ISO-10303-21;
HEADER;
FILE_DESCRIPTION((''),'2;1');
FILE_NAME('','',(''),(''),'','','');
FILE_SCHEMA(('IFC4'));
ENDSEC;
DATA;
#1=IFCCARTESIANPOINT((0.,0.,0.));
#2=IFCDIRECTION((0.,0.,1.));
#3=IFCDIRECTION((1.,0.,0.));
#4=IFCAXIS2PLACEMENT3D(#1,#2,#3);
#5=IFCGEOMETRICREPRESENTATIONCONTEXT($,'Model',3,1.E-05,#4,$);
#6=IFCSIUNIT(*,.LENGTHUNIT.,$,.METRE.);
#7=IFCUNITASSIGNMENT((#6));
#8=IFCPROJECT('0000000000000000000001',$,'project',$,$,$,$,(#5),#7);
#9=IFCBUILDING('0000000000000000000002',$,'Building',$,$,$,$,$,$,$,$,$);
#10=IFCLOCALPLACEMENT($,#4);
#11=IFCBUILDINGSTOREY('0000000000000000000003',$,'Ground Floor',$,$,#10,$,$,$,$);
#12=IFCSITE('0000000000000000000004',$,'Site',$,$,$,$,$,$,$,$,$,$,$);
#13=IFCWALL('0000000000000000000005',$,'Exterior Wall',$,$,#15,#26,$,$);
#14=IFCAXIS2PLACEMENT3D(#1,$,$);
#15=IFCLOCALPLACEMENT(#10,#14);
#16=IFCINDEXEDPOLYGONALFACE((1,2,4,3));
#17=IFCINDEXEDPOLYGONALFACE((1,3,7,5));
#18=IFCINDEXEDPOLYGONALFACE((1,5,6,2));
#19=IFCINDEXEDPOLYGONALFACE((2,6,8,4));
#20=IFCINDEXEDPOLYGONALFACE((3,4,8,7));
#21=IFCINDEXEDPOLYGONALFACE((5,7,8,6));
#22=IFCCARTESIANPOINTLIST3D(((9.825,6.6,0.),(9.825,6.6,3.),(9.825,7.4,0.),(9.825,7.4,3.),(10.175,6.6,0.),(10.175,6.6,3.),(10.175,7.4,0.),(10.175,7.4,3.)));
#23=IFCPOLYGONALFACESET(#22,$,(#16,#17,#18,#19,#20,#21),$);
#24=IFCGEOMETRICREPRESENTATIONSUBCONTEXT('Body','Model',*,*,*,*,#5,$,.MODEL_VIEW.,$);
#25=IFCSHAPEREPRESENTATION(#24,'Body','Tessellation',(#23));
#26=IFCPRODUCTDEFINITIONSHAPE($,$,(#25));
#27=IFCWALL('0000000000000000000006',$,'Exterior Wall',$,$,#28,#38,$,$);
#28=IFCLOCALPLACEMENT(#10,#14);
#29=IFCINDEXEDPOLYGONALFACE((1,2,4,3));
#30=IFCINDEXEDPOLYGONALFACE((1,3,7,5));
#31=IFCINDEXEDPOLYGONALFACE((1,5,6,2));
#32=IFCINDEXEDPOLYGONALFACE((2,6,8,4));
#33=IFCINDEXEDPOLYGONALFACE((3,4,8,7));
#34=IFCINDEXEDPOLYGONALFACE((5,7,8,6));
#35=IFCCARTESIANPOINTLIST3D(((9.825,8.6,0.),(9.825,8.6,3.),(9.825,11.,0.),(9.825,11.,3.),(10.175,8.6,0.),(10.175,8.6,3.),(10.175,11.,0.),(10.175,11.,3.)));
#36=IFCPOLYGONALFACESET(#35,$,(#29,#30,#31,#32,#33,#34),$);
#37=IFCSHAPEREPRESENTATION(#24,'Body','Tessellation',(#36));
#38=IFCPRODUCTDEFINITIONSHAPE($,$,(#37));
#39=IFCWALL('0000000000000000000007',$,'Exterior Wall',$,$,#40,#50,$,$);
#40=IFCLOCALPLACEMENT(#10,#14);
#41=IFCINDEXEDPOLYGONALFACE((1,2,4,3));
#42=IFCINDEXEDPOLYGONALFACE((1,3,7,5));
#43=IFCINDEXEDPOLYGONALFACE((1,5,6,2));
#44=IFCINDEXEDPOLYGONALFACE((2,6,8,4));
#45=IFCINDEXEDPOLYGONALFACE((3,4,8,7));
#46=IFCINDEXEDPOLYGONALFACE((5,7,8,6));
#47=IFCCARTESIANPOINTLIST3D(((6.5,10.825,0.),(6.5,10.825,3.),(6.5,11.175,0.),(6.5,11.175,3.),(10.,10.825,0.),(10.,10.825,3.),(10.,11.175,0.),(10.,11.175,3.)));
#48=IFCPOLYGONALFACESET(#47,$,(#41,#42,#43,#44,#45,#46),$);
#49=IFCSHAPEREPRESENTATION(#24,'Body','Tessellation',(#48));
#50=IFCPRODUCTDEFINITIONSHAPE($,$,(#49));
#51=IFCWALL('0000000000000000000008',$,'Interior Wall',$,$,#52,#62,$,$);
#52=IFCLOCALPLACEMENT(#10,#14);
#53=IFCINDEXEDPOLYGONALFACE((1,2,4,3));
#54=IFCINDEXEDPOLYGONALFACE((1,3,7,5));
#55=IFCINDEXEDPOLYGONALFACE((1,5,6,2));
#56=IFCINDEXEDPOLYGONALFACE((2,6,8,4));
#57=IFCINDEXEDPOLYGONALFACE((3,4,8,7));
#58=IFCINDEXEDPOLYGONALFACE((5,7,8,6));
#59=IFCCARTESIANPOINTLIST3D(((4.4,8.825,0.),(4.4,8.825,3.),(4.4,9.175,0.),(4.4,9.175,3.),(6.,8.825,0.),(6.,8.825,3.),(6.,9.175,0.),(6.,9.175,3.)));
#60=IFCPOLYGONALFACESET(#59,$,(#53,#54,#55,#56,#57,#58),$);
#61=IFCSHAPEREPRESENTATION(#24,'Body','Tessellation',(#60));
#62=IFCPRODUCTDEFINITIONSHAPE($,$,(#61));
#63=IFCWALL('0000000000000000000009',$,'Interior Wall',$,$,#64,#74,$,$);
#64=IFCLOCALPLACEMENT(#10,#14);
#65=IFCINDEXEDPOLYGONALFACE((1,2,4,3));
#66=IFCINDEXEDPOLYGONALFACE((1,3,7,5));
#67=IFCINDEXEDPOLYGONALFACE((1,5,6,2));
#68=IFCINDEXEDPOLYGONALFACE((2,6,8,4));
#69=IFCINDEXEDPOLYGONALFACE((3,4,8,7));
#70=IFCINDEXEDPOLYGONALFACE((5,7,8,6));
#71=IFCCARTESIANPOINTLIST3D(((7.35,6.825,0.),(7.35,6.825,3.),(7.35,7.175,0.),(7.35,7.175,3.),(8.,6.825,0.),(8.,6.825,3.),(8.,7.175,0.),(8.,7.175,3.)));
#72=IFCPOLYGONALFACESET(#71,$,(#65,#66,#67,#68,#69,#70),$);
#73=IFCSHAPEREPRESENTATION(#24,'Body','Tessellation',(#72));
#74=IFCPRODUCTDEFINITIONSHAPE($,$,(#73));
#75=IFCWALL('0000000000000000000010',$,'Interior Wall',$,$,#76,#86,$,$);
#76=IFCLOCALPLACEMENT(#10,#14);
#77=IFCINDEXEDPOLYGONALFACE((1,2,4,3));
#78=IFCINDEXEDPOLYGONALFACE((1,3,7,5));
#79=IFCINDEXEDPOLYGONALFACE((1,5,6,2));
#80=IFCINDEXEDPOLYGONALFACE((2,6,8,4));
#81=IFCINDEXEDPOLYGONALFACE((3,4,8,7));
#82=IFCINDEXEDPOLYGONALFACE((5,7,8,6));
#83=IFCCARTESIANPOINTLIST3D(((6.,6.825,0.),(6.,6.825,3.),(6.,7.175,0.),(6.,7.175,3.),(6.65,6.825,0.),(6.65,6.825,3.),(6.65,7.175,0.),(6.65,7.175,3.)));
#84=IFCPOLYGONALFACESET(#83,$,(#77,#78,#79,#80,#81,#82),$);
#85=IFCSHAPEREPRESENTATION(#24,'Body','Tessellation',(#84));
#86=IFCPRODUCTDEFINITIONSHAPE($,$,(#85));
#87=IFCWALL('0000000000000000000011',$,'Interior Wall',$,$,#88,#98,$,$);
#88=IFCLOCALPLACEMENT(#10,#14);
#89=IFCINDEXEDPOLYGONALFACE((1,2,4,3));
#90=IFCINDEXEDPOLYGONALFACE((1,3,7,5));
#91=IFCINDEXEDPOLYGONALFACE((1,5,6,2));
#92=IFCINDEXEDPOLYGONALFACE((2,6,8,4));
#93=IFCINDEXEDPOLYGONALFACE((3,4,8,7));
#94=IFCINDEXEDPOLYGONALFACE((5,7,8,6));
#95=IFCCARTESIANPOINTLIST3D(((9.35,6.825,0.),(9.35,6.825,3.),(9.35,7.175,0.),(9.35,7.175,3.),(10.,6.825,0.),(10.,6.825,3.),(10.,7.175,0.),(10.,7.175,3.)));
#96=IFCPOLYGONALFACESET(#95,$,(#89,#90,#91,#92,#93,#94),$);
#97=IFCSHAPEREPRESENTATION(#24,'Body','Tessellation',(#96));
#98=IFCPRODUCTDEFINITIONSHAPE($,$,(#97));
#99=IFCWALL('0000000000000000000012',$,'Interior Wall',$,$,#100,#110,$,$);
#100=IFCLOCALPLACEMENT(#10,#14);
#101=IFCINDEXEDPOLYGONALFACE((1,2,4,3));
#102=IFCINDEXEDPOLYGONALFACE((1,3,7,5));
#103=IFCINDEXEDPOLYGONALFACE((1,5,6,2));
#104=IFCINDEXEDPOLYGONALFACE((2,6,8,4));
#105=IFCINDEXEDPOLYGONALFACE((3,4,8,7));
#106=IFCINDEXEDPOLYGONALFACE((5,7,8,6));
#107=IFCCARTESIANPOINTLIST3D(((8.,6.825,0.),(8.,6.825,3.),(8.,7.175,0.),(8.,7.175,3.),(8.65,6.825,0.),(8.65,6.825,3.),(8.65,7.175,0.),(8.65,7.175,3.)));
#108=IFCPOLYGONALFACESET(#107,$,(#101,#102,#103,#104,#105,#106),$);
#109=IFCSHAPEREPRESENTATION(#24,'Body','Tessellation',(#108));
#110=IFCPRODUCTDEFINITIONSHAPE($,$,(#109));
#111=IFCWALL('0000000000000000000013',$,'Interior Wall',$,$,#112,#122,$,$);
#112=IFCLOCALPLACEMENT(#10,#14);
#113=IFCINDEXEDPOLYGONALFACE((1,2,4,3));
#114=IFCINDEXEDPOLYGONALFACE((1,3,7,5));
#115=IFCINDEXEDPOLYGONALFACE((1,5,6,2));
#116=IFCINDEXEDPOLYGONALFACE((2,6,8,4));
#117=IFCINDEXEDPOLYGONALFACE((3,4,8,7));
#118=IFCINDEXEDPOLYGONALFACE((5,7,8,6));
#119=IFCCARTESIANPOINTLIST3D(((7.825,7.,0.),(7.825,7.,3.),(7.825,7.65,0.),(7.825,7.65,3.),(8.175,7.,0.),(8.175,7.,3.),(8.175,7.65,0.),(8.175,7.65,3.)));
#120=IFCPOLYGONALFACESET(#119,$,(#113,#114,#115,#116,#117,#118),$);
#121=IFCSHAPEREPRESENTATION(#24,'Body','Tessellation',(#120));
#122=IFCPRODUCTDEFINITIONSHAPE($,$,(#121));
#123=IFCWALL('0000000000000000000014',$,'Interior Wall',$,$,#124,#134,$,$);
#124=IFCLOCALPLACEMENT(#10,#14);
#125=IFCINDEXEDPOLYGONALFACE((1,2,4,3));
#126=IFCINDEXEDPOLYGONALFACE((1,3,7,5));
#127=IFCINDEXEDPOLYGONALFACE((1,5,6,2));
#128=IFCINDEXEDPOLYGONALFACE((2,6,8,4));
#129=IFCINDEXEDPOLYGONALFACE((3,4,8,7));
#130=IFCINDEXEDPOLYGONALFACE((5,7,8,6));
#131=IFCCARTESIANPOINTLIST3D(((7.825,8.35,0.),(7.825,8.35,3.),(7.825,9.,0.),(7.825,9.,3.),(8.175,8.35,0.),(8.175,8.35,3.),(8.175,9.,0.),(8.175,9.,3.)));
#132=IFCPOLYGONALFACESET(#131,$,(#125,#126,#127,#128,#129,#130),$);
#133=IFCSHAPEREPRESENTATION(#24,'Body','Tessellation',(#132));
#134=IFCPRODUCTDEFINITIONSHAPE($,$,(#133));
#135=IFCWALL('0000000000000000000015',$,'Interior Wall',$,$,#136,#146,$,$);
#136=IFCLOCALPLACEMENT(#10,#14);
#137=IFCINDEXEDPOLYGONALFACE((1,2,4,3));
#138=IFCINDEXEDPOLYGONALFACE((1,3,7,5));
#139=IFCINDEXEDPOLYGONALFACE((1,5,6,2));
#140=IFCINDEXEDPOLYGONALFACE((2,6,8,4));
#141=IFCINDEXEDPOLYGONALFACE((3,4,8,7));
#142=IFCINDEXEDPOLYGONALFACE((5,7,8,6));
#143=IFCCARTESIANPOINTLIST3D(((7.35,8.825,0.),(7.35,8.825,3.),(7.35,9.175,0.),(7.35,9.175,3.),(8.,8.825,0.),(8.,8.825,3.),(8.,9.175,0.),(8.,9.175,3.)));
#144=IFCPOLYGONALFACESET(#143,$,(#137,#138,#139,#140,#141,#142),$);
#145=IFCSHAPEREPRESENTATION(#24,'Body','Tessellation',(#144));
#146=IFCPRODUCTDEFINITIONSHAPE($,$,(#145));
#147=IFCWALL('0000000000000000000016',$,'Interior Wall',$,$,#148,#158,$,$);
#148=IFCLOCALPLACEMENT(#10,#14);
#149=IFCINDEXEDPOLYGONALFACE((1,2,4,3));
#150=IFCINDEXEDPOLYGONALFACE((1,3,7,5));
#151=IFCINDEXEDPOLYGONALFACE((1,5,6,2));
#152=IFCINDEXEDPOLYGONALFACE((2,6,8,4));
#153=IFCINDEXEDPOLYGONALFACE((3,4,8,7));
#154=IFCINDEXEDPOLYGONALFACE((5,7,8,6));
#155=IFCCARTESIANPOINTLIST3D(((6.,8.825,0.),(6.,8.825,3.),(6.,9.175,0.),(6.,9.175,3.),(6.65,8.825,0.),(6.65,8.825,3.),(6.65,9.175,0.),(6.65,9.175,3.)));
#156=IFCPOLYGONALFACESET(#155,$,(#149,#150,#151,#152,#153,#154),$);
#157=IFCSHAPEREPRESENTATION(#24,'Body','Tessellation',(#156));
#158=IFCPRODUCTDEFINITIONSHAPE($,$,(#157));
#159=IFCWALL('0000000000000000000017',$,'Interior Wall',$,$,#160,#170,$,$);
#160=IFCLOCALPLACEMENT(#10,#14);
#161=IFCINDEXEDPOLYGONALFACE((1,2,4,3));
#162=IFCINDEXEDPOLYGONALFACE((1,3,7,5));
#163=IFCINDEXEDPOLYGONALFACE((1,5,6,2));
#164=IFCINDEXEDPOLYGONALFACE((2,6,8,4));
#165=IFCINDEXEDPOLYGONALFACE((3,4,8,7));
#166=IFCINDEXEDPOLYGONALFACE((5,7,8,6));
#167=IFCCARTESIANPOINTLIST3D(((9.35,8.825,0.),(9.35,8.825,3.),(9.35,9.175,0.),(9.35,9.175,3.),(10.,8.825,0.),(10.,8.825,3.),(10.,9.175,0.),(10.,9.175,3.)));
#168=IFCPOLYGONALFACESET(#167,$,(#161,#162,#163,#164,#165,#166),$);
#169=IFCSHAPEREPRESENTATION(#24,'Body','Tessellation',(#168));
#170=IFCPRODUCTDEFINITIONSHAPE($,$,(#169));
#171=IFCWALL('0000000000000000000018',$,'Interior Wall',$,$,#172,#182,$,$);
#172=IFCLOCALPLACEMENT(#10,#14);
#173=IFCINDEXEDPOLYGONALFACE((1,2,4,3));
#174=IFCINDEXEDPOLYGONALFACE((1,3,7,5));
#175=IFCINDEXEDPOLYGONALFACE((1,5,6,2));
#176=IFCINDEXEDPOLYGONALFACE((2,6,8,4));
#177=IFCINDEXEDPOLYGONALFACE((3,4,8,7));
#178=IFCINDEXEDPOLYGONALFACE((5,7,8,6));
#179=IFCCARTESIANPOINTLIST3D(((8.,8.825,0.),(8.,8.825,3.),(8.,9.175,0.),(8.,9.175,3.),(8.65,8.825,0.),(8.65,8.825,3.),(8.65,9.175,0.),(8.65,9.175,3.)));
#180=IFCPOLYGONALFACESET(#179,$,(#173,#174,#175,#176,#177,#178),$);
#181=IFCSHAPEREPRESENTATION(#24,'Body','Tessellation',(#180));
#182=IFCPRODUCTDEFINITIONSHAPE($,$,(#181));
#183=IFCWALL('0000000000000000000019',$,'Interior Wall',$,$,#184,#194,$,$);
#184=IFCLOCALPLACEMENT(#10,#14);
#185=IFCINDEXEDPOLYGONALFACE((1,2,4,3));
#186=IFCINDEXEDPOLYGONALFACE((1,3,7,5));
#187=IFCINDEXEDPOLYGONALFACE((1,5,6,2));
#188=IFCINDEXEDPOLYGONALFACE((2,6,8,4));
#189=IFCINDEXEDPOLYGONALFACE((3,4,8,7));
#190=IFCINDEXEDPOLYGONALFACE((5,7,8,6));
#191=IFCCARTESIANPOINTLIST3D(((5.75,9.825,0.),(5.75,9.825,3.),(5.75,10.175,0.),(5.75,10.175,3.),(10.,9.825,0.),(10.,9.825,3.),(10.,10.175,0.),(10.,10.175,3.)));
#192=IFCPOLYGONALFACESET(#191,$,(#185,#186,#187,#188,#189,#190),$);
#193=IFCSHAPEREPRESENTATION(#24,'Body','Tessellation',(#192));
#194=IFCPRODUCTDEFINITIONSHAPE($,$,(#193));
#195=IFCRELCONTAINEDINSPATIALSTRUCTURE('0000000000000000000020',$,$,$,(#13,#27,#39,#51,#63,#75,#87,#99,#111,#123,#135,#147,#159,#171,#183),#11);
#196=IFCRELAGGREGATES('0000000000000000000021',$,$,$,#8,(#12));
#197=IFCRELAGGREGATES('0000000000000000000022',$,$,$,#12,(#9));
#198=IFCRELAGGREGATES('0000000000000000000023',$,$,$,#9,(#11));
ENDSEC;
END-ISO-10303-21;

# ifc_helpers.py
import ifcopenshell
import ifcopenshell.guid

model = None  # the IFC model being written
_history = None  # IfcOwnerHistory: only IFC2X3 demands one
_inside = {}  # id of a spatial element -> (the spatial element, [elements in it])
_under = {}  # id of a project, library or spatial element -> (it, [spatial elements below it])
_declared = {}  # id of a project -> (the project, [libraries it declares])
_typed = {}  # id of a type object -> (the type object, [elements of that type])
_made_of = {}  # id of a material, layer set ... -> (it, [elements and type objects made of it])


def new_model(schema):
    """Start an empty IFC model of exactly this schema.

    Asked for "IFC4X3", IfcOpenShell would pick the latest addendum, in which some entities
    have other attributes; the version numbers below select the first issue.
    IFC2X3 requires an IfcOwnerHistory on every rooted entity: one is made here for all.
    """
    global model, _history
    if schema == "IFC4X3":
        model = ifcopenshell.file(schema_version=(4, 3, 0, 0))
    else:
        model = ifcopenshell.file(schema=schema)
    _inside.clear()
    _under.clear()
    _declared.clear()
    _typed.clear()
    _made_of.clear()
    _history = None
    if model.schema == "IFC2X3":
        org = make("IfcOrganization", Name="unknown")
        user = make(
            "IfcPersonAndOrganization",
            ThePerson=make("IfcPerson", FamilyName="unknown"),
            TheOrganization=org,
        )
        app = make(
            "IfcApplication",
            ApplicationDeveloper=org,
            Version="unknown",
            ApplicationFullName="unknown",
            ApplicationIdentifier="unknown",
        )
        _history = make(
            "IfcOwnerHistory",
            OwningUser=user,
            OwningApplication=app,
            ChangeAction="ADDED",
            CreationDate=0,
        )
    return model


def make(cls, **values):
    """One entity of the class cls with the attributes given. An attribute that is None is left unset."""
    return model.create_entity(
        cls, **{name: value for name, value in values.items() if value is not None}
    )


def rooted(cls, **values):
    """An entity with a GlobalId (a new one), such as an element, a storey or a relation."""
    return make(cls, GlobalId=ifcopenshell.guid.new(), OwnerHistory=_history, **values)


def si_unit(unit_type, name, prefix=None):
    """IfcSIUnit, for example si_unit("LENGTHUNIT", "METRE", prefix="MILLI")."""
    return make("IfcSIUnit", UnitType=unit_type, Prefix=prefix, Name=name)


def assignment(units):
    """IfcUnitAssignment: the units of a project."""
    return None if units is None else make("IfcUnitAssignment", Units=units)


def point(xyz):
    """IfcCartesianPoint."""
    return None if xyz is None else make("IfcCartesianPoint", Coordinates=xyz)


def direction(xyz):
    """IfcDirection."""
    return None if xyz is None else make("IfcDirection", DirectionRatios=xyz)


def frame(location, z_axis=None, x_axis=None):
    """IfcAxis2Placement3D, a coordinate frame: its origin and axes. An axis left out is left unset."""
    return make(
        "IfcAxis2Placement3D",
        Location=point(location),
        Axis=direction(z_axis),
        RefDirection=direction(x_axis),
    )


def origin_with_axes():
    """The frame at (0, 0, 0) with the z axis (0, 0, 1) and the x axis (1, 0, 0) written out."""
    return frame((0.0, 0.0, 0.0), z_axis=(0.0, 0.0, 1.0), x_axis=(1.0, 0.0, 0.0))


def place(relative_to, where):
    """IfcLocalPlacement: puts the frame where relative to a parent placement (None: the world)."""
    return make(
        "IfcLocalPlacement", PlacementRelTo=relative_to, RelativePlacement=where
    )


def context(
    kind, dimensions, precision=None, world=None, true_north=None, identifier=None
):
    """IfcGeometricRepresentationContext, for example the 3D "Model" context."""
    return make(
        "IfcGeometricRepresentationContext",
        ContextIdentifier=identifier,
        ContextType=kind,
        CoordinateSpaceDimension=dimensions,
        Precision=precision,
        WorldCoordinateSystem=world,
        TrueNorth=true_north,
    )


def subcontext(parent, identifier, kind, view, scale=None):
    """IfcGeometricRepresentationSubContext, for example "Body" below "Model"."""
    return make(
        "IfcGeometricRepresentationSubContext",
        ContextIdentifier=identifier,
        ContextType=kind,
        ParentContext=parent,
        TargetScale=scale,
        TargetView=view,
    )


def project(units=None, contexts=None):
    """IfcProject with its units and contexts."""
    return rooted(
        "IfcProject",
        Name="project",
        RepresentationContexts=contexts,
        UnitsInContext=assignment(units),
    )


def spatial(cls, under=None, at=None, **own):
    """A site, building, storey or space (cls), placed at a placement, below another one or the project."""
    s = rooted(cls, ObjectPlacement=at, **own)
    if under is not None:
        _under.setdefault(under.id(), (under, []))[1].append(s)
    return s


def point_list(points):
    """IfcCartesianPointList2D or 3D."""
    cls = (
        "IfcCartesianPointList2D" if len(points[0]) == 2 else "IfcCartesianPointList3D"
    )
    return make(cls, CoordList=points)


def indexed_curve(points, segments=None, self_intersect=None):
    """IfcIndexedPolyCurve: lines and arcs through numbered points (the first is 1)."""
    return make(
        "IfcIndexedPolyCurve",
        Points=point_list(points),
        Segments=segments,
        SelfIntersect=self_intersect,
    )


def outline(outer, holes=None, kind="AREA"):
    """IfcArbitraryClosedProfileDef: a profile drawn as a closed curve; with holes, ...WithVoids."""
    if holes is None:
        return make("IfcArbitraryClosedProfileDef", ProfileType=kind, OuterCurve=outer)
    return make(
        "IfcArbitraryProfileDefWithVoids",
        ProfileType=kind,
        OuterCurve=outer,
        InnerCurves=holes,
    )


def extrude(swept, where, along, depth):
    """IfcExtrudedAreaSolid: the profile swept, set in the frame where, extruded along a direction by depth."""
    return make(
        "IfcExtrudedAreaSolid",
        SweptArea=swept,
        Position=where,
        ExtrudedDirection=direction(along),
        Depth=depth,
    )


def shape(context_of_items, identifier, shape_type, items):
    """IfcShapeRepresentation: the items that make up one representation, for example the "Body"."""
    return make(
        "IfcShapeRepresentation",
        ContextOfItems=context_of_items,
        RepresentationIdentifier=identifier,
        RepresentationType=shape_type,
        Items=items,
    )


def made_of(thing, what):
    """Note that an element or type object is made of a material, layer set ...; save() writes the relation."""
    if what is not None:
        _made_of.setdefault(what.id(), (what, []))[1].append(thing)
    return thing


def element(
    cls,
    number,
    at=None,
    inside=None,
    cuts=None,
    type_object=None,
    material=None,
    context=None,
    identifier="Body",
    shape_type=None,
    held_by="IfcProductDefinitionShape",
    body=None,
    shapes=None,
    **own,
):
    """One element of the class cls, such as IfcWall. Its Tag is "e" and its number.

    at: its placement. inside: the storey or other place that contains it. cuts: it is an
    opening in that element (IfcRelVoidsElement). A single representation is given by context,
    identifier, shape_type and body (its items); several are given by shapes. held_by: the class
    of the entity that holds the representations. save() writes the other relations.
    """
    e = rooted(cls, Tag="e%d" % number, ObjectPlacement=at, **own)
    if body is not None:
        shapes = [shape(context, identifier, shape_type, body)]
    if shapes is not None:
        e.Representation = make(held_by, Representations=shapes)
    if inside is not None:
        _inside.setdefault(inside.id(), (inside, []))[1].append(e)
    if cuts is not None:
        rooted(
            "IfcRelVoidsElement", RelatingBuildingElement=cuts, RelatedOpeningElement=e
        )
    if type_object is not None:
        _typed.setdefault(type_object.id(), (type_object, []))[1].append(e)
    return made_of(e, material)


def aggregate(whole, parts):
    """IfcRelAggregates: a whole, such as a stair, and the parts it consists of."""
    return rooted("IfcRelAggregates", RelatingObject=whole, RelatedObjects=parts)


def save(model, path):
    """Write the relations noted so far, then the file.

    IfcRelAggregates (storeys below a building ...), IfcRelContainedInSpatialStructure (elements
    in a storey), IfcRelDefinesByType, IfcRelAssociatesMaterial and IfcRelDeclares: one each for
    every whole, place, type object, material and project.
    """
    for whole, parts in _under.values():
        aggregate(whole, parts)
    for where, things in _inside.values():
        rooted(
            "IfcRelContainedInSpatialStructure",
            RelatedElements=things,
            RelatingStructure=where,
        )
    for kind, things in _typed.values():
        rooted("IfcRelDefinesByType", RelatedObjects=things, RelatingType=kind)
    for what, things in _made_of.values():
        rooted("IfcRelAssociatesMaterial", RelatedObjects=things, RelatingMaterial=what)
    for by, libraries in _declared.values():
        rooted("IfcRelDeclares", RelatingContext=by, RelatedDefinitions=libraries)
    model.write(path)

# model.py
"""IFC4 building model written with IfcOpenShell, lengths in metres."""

from ifc_helpers import new_model, si_unit, frame, origin_with_axes, place, context, subcontext, project, spatial, indexed_curve, outline, extrude, element, save


model = new_model("IFC4")

# Units and contexts
model_context = context("Model", 3, precision=1e-05, world=origin_with_axes())
body_context = subcontext(model_context, "Body", "Model", "MODEL_VIEW")
ifc_project = project(units=[si_unit("LENGTHUNIT", "METRE")], contexts=[model_context])

# Site, building, storey
site = spatial("IfcSite", under=ifc_project, Name="Site")
building = spatial("IfcBuilding", under=site, Name="Building")
storey_placement = place(None, origin_with_axes())
storey = spatial("IfcBuildingStorey", under=building, at=storey_placement, Name="Ground Floor")

# Walls
wall_1_placement = place(storey_placement, frame((10.0, 6.6, 0.0), z_axis=(0.0, 0.0, 1.0), x_axis=(0.0, 1.0, 0.0)))
element("IfcWall", 1, at=wall_1_placement, inside=storey, Name="Exterior Wall", context=body_context, shape_type="SweptSolid", body=[
    extrude(outline(indexed_curve([(0.0, 0.0), (0.0, 0.35), (0.8, 0.35), (0.8, 0.0), (0.0, 0.0)], self_intersect=False)), frame((0.0, -0.175, 0.0), z_axis=(0.0, 0.0, 1.0), x_axis=(1.0, 0.0, 0.0)), (0.0, 0.0, 1.0), 3.0),
])
wall_2_placement = place(storey_placement, frame((10.0, 8.6, 0.0), z_axis=(0.0, 0.0, 1.0), x_axis=(0.0, 1.0, 0.0)))
element("IfcWall", 2, at=wall_2_placement, inside=storey, Name="Exterior Wall", context=body_context, shape_type="SweptSolid", body=[
    extrude(outline(indexed_curve([(0.0, 0.0), (0.0, 0.35), (2.4, 0.35), (2.4, 0.0), (0.0, 0.0)], self_intersect=False)), frame((0.0, -0.175, 0.0), z_axis=(0.0, 0.0, 1.0), x_axis=(1.0, 0.0, 0.0)), (0.0, 0.0, 1.0), 3.0),
])
wall_3_placement = place(storey_placement, frame((10.0, 11.0, 0.0), z_axis=(0.0, 0.0, 1.0), x_axis=(-1.0, 0.0, 0.0)))
element("IfcWall", 3, at=wall_3_placement, inside=storey, Name="Exterior Wall", context=body_context, shape_type="SweptSolid", body=[
    extrude(outline(indexed_curve([(0.0, 0.0), (0.0, 0.35), (3.5, 0.35), (3.5, 0.0), (0.0, 0.0)], self_intersect=False)), frame((0.0, -0.175, 0.0), z_axis=(0.0, 0.0, 1.0), x_axis=(1.0, 0.0, 0.0)), (0.0, 0.0, 1.0), 3.0),
])
wall_4_placement = place(storey_placement, frame((6.0, 9.0, 0.0), z_axis=(0.0, 0.0, 1.0), x_axis=(-1.0, 0.0, 0.0)))
element("IfcWall", 4, at=wall_4_placement, inside=storey, Name="Interior Wall", context=body_context, shape_type="SweptSolid", body=[
    extrude(outline(indexed_curve([(0.0, 0.0), (0.0, 0.35), (1.6, 0.35), (1.6, 0.0), (0.0, 0.0)], self_intersect=False)), frame((0.0, -0.175, 0.0), z_axis=(0.0, 0.0, 1.0), x_axis=(1.0, 0.0, 0.0)), (0.0, 0.0, 1.0), 3.0),
])
for number, where, z_axis, x_axis, name in (
    (5, (8.0, 7.0, 0.0), (0.0, 0.0, 1.0), (-1.0, 0.0, 0.0), "Interior Wall"),
    (6, (6.65, 7.0, 0.0), (0.0, 0.0, 1.0), (-1.0, 0.0, 0.0), "Interior Wall"),
    (7, (10.0, 7.0, 0.0), (0.0, 0.0, 1.0), (-1.0, 0.0, 0.0), "Interior Wall"),
    (8, (8.65, 7.0, 0.0), (0.0, 0.0, 1.0), (-1.0, 0.0, 0.0), "Interior Wall"),
    (9, (8.0, 7.0, 0.0), (0.0, 0.0, 1.0), (0.0, 1.0, 0.0), "Interior Wall"),
    (10, (8.0, 8.35, 0.0), (0.0, 0.0, 1.0), (0.0, 1.0, 0.0), "Interior Wall"),
    (11, (8.0, 9.0, 0.0), (0.0, 0.0, 1.0), (-1.0, 0.0, 0.0), "Interior Wall"),
    (12, (6.65, 9.0, 0.0), (0.0, 0.0, 1.0), (-1.0, 0.0, 0.0), "Interior Wall"),
    (13, (10.0, 9.0, 0.0), (0.0, 0.0, 1.0), (-1.0, 0.0, 0.0), "Interior Wall"),
    (14, (8.65, 9.0, 0.0), (0.0, 0.0, 1.0), (-1.0, 0.0, 0.0), "Interior Wall"),
):
    element("IfcWall", number, at=place(storey_placement, frame(where, z_axis=z_axis, x_axis=x_axis)), inside=storey, Name=name, context=body_context, shape_type="SweptSolid", body=[
        extrude(outline(indexed_curve([(0.0, 0.0), (0.0, 0.35), (0.65, 0.35), (0.65, 0.0), (0.0, 0.0)], self_intersect=False)), frame((0.0, -0.175, 0.0), z_axis=(0.0, 0.0, 1.0), x_axis=(1.0, 0.0, 0.0)), (0.0, 0.0, 1.0), 3.0),
    ])
wall_5_placement = place(storey_placement, frame((10.0, 10.0, 0.0), z_axis=(0.0, 0.0, 1.0), x_axis=(-1.0, 0.0, 0.0)))
element("IfcWall", 15, at=wall_5_placement, inside=storey, Name="Interior Wall", context=body_context, shape_type="SweptSolid", body=[
    extrude(outline(indexed_curve([(0.0, 0.0), (0.0, 0.35), (4.25, 0.35), (4.25, 0.0), (0.0, 0.0)], self_intersect=False)), frame((0.0, -0.175, 0.0), z_axis=(0.0, 0.0, 1.0), x_axis=(1.0, 0.0, 0.0)), (0.0, 0.0, 1.0), 3.0),
])

save(model, "model.ifc")
